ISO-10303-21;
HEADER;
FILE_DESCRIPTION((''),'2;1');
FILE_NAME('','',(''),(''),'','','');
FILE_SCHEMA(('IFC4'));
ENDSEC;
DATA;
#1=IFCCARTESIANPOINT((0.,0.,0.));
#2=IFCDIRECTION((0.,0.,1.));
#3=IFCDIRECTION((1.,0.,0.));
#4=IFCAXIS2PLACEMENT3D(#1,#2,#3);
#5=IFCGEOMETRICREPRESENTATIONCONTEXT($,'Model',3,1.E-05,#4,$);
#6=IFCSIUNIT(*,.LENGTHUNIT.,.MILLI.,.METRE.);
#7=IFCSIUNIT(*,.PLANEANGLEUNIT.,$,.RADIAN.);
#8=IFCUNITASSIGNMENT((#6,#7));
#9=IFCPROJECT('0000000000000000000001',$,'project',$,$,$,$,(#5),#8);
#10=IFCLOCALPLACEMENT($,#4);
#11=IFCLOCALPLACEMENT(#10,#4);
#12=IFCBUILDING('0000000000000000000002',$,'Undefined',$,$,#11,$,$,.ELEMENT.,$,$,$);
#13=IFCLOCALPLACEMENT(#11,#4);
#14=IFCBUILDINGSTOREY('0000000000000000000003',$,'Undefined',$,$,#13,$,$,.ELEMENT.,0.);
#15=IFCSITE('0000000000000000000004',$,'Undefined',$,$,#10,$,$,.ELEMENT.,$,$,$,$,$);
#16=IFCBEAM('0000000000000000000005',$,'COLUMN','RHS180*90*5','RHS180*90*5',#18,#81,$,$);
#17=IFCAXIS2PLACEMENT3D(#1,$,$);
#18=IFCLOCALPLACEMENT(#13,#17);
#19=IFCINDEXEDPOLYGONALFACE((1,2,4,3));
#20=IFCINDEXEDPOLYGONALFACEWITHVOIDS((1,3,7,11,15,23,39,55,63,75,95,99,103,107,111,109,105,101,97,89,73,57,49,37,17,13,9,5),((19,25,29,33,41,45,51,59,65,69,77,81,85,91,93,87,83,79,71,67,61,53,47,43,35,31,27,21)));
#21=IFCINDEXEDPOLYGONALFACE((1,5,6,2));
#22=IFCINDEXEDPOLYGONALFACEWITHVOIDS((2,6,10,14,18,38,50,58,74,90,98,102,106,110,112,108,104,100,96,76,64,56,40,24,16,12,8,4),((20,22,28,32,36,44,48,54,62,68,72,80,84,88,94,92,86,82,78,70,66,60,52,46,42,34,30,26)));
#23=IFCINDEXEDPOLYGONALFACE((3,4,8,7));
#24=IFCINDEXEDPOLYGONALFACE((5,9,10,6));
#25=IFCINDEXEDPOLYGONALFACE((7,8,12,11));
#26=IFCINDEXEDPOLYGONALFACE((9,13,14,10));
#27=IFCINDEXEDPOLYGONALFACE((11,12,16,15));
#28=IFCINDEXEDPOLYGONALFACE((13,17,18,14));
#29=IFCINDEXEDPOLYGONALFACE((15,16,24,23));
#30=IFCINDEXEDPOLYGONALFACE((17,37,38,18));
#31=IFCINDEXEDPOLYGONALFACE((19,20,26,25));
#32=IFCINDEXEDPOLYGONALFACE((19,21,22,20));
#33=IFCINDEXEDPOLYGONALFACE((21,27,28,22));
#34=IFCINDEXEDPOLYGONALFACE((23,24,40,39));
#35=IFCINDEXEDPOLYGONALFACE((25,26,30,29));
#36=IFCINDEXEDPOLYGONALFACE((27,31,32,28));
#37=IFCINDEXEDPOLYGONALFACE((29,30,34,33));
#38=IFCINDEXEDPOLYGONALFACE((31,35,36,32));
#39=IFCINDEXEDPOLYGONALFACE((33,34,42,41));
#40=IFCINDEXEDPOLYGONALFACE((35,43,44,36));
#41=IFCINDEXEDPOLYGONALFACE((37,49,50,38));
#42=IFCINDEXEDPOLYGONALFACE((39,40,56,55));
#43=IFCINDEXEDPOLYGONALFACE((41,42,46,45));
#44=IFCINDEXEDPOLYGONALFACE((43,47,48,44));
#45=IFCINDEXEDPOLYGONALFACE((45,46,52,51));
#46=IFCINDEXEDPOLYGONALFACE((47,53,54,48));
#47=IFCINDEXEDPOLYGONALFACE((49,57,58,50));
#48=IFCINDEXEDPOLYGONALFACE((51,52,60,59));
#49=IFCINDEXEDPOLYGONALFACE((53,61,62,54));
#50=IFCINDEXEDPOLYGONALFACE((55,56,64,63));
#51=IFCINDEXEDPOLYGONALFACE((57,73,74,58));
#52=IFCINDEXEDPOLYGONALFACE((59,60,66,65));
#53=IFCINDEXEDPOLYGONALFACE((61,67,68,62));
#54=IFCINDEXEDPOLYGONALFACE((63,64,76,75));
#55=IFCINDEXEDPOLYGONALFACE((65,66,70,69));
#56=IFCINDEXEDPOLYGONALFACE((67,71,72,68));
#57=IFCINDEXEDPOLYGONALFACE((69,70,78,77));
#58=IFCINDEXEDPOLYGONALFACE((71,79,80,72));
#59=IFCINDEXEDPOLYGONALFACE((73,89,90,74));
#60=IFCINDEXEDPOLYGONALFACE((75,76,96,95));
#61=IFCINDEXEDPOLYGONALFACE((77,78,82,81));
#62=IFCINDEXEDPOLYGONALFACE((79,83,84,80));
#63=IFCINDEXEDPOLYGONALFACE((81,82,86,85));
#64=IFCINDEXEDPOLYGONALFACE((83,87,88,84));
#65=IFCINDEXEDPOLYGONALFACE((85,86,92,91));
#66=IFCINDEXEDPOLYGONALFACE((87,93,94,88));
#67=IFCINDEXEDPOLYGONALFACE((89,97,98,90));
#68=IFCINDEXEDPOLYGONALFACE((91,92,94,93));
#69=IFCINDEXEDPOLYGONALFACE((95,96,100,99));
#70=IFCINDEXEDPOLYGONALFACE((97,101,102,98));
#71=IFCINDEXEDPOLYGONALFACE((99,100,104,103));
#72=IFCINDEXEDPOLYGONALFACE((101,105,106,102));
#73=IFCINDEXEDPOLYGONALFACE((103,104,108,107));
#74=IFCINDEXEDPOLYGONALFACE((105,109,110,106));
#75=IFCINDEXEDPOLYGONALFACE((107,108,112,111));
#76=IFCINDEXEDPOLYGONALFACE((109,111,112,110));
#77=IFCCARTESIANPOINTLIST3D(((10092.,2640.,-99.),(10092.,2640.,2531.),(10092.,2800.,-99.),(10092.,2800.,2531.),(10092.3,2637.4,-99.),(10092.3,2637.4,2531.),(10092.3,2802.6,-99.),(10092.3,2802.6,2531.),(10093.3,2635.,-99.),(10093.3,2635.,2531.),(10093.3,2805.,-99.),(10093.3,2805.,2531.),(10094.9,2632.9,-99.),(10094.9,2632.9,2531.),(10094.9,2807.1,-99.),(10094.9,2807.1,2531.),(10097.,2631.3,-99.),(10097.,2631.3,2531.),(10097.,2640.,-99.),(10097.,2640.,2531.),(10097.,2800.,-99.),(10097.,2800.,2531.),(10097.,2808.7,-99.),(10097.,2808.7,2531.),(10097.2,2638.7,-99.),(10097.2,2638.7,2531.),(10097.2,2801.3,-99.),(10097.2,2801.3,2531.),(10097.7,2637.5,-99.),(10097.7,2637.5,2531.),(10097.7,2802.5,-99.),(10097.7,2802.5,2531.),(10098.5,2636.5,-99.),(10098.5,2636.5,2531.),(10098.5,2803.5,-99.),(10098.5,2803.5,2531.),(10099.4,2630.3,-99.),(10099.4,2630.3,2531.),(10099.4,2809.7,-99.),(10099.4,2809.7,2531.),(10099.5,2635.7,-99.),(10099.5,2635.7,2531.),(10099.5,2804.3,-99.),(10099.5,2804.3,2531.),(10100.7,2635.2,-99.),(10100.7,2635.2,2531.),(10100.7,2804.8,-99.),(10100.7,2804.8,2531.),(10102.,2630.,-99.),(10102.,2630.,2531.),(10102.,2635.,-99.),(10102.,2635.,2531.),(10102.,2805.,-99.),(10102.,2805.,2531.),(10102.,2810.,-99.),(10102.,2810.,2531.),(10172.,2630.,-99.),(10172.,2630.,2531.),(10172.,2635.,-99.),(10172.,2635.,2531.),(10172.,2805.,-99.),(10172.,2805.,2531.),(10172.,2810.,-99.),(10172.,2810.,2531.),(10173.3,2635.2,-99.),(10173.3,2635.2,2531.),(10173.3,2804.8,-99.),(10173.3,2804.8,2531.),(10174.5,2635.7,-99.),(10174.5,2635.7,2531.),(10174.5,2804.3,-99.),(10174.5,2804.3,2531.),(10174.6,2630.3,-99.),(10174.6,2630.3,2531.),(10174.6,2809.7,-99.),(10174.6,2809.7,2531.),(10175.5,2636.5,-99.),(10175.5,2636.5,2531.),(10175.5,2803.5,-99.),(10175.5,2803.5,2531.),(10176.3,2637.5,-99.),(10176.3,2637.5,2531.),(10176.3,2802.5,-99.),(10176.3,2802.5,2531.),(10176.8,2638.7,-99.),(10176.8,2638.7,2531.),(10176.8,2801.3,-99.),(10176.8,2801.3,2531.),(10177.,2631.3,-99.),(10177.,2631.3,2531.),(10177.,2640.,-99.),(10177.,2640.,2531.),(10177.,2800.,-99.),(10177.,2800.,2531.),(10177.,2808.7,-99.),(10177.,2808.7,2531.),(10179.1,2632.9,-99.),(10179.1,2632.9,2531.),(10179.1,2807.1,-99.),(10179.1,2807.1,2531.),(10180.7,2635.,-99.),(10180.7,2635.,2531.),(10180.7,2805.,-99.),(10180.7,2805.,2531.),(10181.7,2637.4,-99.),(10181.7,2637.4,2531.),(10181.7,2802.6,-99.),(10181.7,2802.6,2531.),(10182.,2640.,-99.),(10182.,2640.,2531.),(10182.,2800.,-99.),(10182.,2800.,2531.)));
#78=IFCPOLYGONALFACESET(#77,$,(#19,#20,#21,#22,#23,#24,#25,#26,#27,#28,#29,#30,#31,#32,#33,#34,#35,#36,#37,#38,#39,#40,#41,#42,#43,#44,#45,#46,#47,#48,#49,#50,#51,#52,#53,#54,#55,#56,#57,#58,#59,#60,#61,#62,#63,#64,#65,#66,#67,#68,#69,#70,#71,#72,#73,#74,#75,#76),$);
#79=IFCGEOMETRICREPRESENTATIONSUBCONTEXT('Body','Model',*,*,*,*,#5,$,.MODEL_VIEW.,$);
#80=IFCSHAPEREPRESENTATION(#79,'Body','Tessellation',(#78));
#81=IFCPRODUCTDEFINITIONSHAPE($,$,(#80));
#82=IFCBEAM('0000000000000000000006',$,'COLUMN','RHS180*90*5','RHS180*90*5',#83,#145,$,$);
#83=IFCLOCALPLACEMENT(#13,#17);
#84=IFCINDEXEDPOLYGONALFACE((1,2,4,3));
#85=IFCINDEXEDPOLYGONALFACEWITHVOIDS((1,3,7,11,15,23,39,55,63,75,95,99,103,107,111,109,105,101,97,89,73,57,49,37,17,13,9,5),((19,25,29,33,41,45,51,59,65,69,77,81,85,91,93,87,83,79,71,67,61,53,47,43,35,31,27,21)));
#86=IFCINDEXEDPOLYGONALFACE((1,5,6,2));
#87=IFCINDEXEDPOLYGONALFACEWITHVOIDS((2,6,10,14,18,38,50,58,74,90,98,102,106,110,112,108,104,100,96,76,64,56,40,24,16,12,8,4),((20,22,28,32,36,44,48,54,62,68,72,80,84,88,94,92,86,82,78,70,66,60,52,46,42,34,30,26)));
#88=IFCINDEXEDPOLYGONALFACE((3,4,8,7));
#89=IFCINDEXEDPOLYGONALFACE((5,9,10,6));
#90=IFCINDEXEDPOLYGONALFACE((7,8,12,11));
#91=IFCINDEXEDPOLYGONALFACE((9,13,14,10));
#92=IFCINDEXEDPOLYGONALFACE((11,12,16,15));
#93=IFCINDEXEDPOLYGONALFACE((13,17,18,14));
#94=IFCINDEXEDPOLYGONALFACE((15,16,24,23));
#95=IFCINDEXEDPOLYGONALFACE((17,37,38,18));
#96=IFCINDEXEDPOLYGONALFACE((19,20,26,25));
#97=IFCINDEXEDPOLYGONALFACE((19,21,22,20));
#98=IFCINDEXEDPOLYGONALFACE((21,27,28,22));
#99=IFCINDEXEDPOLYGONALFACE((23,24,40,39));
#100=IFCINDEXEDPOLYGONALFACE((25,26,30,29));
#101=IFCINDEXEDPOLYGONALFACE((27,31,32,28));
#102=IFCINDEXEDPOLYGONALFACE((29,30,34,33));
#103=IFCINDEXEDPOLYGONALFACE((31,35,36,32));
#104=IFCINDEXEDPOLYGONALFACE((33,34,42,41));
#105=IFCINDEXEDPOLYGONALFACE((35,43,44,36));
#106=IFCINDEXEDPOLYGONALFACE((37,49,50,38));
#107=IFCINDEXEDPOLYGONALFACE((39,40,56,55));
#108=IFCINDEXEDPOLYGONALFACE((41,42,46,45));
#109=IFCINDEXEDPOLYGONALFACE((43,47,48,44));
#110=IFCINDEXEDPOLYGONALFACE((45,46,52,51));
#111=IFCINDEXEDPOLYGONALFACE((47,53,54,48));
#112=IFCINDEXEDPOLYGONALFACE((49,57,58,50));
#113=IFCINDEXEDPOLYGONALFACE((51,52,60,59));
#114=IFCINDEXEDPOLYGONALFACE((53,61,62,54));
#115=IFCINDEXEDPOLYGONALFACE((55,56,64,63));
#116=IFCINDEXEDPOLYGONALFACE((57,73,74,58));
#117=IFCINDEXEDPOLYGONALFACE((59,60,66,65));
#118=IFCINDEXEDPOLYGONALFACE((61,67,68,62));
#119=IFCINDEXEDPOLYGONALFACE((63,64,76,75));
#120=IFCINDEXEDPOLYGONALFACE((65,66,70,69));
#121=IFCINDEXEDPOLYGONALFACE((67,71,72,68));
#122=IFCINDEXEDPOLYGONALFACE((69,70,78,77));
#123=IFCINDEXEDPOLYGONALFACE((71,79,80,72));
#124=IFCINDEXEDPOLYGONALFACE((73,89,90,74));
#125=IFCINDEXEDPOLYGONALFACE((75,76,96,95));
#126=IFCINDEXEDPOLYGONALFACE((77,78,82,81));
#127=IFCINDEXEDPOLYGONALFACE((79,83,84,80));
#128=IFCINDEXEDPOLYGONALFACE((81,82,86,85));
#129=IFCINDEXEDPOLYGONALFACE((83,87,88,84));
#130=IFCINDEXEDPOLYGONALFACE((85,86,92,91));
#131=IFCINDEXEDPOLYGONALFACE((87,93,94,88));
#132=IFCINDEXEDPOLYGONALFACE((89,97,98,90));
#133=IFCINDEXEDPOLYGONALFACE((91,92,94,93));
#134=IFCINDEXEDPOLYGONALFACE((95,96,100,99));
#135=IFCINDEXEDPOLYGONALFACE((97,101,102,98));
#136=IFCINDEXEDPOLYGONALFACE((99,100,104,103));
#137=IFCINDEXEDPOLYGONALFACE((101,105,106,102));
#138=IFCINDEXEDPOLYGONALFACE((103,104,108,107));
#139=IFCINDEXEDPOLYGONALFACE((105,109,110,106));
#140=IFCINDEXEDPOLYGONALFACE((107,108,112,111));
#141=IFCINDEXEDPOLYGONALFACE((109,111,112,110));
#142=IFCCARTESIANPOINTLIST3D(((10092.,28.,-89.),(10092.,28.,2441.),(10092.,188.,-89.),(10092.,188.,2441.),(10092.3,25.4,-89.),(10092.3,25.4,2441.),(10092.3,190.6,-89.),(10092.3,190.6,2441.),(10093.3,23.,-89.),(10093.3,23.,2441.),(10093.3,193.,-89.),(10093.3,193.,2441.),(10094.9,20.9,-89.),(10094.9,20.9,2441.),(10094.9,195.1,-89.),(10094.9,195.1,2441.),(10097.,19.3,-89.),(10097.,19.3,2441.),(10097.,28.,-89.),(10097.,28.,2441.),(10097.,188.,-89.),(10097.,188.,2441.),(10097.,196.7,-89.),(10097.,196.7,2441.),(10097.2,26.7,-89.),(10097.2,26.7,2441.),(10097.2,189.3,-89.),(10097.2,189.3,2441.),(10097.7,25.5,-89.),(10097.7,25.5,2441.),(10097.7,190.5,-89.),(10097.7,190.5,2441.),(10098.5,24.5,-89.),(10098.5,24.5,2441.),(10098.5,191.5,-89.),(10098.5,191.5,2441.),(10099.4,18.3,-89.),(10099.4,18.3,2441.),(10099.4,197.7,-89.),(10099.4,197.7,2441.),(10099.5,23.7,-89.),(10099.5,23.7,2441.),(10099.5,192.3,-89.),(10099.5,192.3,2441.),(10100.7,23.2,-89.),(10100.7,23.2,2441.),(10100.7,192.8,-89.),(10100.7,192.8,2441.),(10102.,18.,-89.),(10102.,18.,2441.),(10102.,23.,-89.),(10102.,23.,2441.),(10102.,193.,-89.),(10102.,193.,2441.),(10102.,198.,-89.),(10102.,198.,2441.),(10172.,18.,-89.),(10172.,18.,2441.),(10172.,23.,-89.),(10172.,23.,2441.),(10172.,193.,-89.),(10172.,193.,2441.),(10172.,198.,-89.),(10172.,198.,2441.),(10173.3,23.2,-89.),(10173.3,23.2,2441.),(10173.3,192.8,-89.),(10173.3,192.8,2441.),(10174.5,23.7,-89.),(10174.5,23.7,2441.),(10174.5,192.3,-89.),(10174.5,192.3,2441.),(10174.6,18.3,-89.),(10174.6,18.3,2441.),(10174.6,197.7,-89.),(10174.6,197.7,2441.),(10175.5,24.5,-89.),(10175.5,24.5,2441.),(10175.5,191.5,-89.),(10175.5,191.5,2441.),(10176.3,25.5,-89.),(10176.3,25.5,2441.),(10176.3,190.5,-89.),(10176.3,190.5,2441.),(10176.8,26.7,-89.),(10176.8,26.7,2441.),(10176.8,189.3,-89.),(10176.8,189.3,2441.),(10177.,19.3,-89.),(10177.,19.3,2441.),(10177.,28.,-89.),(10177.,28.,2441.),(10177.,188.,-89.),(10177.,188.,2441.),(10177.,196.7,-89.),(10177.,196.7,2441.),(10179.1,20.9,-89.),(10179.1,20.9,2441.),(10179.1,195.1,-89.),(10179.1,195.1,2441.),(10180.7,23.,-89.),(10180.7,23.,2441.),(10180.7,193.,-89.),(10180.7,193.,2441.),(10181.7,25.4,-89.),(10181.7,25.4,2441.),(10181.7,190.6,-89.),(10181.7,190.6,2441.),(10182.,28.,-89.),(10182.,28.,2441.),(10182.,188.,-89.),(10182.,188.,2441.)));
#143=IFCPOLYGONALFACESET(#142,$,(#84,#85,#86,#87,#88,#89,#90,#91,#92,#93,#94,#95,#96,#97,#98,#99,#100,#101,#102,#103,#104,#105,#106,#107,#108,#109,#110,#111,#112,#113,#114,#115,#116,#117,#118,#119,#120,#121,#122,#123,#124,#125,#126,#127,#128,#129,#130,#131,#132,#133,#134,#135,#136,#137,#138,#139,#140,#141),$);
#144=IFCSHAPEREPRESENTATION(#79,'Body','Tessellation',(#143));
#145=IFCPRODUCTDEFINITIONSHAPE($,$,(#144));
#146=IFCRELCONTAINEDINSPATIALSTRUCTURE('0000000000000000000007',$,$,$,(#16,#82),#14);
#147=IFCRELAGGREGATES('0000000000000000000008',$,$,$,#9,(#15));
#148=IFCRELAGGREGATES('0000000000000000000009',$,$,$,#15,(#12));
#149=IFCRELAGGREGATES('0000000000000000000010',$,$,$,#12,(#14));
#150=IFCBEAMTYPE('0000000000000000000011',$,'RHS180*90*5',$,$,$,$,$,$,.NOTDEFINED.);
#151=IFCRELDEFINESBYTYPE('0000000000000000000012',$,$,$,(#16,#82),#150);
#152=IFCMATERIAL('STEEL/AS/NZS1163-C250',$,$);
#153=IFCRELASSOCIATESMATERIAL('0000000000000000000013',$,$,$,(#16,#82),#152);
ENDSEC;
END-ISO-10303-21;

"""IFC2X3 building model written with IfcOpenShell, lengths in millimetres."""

from ifc_helpers import new_model, si_unit, frame, origin_with_axes, origin_2d_with_axis, place, context, subcontext, project, spatial, hollow_rectangle, extrude, material, type_object, element, save


model = new_model("IFC2X3")

# Units and contexts
model_context = context("Model", 3, precision=1e-05, world=origin_with_axes())
body_context = subcontext(model_context, "Body", "Model", "MODEL_VIEW")
ifc_project = project(units=[si_unit("LENGTHUNIT", "METRE", prefix="MILLI"), si_unit("PLANEANGLEUNIT", "RADIAN")], contexts=[model_context])

# Site, building, storey
site_placement = place(None, origin_with_axes())
site = spatial("IfcSite", under=ifc_project, at=site_placement, Name="Undefined", CompositionType="ELEMENT")
building_placement = place(site_placement, origin_with_axes())
building = spatial("IfcBuilding", under=site, at=building_placement, Name="Undefined", CompositionType="ELEMENT")
storey_placement = place(building_placement, origin_with_axes())
storey = spatial("IfcBuildingStorey", under=building, at=storey_placement, Name="Undefined", CompositionType="ELEMENT", Elevation=0.0)

# Shared definitions
ifc_material_1 = material(Name="STEEL/AS/NZS1163-C250")

# Beams
beam_type_1 = type_object("IfcBeamType", Name="RHS180*90*5", PredefinedType="NOTDEFINED")
beam_1_placement = place(storey_placement, frame((10137.0, 2720.0, 2531.0), z_axis=(0.0, 1.0, 0.0), x_axis=(0.0, 0.0, -1.0)))
element("IfcBeam", 1, at=beam_1_placement, inside=storey, type_object=beam_type_1, material=ifc_material_1, Name="COLUMN", Description="RHS180*90*5", ObjectType="RHS180*90*5", context=body_context, shape_type="SweptSolid", body=[
    extrude(hollow_rectangle(XDim=90.0, YDim=180.0, WallThickness=5.0, InnerFilletRadius=5.0, OuterFilletRadius=10.0, at=origin_2d_with_axis()), frame((2630.0, 0.0, 0.0), z_axis=(-1.0, 0.0, 0.0), x_axis=(0.0, -1.0, 0.0)), (0.0, 0.0, 1.0), 2630.0),
])
beam_2_placement = place(storey_placement, frame((10137.0, 108.0, 2441.0), z_axis=(0.0, 1.0, 0.0), x_axis=(0.0, 0.0, -1.0)))
element("IfcBeam", 2, at=beam_2_placement, inside=storey, type_object=beam_type_1, material=ifc_material_1, Name="COLUMN", Description="RHS180*90*5", ObjectType="RHS180*90*5", context=body_context, shape_type="SweptSolid", body=[
    extrude(hollow_rectangle(XDim=90.0, YDim=180.0, WallThickness=5.0, InnerFilletRadius=5.0, OuterFilletRadius=10.0, at=origin_2d_with_axis()), frame((2530.0, 0.0, 0.0), z_axis=(-1.0, 0.0, 0.0), x_axis=(0.0, -1.0, 0.0)), (0.0, 0.0, 1.0), 2530.0),
])

save(model, "model.ifc")
